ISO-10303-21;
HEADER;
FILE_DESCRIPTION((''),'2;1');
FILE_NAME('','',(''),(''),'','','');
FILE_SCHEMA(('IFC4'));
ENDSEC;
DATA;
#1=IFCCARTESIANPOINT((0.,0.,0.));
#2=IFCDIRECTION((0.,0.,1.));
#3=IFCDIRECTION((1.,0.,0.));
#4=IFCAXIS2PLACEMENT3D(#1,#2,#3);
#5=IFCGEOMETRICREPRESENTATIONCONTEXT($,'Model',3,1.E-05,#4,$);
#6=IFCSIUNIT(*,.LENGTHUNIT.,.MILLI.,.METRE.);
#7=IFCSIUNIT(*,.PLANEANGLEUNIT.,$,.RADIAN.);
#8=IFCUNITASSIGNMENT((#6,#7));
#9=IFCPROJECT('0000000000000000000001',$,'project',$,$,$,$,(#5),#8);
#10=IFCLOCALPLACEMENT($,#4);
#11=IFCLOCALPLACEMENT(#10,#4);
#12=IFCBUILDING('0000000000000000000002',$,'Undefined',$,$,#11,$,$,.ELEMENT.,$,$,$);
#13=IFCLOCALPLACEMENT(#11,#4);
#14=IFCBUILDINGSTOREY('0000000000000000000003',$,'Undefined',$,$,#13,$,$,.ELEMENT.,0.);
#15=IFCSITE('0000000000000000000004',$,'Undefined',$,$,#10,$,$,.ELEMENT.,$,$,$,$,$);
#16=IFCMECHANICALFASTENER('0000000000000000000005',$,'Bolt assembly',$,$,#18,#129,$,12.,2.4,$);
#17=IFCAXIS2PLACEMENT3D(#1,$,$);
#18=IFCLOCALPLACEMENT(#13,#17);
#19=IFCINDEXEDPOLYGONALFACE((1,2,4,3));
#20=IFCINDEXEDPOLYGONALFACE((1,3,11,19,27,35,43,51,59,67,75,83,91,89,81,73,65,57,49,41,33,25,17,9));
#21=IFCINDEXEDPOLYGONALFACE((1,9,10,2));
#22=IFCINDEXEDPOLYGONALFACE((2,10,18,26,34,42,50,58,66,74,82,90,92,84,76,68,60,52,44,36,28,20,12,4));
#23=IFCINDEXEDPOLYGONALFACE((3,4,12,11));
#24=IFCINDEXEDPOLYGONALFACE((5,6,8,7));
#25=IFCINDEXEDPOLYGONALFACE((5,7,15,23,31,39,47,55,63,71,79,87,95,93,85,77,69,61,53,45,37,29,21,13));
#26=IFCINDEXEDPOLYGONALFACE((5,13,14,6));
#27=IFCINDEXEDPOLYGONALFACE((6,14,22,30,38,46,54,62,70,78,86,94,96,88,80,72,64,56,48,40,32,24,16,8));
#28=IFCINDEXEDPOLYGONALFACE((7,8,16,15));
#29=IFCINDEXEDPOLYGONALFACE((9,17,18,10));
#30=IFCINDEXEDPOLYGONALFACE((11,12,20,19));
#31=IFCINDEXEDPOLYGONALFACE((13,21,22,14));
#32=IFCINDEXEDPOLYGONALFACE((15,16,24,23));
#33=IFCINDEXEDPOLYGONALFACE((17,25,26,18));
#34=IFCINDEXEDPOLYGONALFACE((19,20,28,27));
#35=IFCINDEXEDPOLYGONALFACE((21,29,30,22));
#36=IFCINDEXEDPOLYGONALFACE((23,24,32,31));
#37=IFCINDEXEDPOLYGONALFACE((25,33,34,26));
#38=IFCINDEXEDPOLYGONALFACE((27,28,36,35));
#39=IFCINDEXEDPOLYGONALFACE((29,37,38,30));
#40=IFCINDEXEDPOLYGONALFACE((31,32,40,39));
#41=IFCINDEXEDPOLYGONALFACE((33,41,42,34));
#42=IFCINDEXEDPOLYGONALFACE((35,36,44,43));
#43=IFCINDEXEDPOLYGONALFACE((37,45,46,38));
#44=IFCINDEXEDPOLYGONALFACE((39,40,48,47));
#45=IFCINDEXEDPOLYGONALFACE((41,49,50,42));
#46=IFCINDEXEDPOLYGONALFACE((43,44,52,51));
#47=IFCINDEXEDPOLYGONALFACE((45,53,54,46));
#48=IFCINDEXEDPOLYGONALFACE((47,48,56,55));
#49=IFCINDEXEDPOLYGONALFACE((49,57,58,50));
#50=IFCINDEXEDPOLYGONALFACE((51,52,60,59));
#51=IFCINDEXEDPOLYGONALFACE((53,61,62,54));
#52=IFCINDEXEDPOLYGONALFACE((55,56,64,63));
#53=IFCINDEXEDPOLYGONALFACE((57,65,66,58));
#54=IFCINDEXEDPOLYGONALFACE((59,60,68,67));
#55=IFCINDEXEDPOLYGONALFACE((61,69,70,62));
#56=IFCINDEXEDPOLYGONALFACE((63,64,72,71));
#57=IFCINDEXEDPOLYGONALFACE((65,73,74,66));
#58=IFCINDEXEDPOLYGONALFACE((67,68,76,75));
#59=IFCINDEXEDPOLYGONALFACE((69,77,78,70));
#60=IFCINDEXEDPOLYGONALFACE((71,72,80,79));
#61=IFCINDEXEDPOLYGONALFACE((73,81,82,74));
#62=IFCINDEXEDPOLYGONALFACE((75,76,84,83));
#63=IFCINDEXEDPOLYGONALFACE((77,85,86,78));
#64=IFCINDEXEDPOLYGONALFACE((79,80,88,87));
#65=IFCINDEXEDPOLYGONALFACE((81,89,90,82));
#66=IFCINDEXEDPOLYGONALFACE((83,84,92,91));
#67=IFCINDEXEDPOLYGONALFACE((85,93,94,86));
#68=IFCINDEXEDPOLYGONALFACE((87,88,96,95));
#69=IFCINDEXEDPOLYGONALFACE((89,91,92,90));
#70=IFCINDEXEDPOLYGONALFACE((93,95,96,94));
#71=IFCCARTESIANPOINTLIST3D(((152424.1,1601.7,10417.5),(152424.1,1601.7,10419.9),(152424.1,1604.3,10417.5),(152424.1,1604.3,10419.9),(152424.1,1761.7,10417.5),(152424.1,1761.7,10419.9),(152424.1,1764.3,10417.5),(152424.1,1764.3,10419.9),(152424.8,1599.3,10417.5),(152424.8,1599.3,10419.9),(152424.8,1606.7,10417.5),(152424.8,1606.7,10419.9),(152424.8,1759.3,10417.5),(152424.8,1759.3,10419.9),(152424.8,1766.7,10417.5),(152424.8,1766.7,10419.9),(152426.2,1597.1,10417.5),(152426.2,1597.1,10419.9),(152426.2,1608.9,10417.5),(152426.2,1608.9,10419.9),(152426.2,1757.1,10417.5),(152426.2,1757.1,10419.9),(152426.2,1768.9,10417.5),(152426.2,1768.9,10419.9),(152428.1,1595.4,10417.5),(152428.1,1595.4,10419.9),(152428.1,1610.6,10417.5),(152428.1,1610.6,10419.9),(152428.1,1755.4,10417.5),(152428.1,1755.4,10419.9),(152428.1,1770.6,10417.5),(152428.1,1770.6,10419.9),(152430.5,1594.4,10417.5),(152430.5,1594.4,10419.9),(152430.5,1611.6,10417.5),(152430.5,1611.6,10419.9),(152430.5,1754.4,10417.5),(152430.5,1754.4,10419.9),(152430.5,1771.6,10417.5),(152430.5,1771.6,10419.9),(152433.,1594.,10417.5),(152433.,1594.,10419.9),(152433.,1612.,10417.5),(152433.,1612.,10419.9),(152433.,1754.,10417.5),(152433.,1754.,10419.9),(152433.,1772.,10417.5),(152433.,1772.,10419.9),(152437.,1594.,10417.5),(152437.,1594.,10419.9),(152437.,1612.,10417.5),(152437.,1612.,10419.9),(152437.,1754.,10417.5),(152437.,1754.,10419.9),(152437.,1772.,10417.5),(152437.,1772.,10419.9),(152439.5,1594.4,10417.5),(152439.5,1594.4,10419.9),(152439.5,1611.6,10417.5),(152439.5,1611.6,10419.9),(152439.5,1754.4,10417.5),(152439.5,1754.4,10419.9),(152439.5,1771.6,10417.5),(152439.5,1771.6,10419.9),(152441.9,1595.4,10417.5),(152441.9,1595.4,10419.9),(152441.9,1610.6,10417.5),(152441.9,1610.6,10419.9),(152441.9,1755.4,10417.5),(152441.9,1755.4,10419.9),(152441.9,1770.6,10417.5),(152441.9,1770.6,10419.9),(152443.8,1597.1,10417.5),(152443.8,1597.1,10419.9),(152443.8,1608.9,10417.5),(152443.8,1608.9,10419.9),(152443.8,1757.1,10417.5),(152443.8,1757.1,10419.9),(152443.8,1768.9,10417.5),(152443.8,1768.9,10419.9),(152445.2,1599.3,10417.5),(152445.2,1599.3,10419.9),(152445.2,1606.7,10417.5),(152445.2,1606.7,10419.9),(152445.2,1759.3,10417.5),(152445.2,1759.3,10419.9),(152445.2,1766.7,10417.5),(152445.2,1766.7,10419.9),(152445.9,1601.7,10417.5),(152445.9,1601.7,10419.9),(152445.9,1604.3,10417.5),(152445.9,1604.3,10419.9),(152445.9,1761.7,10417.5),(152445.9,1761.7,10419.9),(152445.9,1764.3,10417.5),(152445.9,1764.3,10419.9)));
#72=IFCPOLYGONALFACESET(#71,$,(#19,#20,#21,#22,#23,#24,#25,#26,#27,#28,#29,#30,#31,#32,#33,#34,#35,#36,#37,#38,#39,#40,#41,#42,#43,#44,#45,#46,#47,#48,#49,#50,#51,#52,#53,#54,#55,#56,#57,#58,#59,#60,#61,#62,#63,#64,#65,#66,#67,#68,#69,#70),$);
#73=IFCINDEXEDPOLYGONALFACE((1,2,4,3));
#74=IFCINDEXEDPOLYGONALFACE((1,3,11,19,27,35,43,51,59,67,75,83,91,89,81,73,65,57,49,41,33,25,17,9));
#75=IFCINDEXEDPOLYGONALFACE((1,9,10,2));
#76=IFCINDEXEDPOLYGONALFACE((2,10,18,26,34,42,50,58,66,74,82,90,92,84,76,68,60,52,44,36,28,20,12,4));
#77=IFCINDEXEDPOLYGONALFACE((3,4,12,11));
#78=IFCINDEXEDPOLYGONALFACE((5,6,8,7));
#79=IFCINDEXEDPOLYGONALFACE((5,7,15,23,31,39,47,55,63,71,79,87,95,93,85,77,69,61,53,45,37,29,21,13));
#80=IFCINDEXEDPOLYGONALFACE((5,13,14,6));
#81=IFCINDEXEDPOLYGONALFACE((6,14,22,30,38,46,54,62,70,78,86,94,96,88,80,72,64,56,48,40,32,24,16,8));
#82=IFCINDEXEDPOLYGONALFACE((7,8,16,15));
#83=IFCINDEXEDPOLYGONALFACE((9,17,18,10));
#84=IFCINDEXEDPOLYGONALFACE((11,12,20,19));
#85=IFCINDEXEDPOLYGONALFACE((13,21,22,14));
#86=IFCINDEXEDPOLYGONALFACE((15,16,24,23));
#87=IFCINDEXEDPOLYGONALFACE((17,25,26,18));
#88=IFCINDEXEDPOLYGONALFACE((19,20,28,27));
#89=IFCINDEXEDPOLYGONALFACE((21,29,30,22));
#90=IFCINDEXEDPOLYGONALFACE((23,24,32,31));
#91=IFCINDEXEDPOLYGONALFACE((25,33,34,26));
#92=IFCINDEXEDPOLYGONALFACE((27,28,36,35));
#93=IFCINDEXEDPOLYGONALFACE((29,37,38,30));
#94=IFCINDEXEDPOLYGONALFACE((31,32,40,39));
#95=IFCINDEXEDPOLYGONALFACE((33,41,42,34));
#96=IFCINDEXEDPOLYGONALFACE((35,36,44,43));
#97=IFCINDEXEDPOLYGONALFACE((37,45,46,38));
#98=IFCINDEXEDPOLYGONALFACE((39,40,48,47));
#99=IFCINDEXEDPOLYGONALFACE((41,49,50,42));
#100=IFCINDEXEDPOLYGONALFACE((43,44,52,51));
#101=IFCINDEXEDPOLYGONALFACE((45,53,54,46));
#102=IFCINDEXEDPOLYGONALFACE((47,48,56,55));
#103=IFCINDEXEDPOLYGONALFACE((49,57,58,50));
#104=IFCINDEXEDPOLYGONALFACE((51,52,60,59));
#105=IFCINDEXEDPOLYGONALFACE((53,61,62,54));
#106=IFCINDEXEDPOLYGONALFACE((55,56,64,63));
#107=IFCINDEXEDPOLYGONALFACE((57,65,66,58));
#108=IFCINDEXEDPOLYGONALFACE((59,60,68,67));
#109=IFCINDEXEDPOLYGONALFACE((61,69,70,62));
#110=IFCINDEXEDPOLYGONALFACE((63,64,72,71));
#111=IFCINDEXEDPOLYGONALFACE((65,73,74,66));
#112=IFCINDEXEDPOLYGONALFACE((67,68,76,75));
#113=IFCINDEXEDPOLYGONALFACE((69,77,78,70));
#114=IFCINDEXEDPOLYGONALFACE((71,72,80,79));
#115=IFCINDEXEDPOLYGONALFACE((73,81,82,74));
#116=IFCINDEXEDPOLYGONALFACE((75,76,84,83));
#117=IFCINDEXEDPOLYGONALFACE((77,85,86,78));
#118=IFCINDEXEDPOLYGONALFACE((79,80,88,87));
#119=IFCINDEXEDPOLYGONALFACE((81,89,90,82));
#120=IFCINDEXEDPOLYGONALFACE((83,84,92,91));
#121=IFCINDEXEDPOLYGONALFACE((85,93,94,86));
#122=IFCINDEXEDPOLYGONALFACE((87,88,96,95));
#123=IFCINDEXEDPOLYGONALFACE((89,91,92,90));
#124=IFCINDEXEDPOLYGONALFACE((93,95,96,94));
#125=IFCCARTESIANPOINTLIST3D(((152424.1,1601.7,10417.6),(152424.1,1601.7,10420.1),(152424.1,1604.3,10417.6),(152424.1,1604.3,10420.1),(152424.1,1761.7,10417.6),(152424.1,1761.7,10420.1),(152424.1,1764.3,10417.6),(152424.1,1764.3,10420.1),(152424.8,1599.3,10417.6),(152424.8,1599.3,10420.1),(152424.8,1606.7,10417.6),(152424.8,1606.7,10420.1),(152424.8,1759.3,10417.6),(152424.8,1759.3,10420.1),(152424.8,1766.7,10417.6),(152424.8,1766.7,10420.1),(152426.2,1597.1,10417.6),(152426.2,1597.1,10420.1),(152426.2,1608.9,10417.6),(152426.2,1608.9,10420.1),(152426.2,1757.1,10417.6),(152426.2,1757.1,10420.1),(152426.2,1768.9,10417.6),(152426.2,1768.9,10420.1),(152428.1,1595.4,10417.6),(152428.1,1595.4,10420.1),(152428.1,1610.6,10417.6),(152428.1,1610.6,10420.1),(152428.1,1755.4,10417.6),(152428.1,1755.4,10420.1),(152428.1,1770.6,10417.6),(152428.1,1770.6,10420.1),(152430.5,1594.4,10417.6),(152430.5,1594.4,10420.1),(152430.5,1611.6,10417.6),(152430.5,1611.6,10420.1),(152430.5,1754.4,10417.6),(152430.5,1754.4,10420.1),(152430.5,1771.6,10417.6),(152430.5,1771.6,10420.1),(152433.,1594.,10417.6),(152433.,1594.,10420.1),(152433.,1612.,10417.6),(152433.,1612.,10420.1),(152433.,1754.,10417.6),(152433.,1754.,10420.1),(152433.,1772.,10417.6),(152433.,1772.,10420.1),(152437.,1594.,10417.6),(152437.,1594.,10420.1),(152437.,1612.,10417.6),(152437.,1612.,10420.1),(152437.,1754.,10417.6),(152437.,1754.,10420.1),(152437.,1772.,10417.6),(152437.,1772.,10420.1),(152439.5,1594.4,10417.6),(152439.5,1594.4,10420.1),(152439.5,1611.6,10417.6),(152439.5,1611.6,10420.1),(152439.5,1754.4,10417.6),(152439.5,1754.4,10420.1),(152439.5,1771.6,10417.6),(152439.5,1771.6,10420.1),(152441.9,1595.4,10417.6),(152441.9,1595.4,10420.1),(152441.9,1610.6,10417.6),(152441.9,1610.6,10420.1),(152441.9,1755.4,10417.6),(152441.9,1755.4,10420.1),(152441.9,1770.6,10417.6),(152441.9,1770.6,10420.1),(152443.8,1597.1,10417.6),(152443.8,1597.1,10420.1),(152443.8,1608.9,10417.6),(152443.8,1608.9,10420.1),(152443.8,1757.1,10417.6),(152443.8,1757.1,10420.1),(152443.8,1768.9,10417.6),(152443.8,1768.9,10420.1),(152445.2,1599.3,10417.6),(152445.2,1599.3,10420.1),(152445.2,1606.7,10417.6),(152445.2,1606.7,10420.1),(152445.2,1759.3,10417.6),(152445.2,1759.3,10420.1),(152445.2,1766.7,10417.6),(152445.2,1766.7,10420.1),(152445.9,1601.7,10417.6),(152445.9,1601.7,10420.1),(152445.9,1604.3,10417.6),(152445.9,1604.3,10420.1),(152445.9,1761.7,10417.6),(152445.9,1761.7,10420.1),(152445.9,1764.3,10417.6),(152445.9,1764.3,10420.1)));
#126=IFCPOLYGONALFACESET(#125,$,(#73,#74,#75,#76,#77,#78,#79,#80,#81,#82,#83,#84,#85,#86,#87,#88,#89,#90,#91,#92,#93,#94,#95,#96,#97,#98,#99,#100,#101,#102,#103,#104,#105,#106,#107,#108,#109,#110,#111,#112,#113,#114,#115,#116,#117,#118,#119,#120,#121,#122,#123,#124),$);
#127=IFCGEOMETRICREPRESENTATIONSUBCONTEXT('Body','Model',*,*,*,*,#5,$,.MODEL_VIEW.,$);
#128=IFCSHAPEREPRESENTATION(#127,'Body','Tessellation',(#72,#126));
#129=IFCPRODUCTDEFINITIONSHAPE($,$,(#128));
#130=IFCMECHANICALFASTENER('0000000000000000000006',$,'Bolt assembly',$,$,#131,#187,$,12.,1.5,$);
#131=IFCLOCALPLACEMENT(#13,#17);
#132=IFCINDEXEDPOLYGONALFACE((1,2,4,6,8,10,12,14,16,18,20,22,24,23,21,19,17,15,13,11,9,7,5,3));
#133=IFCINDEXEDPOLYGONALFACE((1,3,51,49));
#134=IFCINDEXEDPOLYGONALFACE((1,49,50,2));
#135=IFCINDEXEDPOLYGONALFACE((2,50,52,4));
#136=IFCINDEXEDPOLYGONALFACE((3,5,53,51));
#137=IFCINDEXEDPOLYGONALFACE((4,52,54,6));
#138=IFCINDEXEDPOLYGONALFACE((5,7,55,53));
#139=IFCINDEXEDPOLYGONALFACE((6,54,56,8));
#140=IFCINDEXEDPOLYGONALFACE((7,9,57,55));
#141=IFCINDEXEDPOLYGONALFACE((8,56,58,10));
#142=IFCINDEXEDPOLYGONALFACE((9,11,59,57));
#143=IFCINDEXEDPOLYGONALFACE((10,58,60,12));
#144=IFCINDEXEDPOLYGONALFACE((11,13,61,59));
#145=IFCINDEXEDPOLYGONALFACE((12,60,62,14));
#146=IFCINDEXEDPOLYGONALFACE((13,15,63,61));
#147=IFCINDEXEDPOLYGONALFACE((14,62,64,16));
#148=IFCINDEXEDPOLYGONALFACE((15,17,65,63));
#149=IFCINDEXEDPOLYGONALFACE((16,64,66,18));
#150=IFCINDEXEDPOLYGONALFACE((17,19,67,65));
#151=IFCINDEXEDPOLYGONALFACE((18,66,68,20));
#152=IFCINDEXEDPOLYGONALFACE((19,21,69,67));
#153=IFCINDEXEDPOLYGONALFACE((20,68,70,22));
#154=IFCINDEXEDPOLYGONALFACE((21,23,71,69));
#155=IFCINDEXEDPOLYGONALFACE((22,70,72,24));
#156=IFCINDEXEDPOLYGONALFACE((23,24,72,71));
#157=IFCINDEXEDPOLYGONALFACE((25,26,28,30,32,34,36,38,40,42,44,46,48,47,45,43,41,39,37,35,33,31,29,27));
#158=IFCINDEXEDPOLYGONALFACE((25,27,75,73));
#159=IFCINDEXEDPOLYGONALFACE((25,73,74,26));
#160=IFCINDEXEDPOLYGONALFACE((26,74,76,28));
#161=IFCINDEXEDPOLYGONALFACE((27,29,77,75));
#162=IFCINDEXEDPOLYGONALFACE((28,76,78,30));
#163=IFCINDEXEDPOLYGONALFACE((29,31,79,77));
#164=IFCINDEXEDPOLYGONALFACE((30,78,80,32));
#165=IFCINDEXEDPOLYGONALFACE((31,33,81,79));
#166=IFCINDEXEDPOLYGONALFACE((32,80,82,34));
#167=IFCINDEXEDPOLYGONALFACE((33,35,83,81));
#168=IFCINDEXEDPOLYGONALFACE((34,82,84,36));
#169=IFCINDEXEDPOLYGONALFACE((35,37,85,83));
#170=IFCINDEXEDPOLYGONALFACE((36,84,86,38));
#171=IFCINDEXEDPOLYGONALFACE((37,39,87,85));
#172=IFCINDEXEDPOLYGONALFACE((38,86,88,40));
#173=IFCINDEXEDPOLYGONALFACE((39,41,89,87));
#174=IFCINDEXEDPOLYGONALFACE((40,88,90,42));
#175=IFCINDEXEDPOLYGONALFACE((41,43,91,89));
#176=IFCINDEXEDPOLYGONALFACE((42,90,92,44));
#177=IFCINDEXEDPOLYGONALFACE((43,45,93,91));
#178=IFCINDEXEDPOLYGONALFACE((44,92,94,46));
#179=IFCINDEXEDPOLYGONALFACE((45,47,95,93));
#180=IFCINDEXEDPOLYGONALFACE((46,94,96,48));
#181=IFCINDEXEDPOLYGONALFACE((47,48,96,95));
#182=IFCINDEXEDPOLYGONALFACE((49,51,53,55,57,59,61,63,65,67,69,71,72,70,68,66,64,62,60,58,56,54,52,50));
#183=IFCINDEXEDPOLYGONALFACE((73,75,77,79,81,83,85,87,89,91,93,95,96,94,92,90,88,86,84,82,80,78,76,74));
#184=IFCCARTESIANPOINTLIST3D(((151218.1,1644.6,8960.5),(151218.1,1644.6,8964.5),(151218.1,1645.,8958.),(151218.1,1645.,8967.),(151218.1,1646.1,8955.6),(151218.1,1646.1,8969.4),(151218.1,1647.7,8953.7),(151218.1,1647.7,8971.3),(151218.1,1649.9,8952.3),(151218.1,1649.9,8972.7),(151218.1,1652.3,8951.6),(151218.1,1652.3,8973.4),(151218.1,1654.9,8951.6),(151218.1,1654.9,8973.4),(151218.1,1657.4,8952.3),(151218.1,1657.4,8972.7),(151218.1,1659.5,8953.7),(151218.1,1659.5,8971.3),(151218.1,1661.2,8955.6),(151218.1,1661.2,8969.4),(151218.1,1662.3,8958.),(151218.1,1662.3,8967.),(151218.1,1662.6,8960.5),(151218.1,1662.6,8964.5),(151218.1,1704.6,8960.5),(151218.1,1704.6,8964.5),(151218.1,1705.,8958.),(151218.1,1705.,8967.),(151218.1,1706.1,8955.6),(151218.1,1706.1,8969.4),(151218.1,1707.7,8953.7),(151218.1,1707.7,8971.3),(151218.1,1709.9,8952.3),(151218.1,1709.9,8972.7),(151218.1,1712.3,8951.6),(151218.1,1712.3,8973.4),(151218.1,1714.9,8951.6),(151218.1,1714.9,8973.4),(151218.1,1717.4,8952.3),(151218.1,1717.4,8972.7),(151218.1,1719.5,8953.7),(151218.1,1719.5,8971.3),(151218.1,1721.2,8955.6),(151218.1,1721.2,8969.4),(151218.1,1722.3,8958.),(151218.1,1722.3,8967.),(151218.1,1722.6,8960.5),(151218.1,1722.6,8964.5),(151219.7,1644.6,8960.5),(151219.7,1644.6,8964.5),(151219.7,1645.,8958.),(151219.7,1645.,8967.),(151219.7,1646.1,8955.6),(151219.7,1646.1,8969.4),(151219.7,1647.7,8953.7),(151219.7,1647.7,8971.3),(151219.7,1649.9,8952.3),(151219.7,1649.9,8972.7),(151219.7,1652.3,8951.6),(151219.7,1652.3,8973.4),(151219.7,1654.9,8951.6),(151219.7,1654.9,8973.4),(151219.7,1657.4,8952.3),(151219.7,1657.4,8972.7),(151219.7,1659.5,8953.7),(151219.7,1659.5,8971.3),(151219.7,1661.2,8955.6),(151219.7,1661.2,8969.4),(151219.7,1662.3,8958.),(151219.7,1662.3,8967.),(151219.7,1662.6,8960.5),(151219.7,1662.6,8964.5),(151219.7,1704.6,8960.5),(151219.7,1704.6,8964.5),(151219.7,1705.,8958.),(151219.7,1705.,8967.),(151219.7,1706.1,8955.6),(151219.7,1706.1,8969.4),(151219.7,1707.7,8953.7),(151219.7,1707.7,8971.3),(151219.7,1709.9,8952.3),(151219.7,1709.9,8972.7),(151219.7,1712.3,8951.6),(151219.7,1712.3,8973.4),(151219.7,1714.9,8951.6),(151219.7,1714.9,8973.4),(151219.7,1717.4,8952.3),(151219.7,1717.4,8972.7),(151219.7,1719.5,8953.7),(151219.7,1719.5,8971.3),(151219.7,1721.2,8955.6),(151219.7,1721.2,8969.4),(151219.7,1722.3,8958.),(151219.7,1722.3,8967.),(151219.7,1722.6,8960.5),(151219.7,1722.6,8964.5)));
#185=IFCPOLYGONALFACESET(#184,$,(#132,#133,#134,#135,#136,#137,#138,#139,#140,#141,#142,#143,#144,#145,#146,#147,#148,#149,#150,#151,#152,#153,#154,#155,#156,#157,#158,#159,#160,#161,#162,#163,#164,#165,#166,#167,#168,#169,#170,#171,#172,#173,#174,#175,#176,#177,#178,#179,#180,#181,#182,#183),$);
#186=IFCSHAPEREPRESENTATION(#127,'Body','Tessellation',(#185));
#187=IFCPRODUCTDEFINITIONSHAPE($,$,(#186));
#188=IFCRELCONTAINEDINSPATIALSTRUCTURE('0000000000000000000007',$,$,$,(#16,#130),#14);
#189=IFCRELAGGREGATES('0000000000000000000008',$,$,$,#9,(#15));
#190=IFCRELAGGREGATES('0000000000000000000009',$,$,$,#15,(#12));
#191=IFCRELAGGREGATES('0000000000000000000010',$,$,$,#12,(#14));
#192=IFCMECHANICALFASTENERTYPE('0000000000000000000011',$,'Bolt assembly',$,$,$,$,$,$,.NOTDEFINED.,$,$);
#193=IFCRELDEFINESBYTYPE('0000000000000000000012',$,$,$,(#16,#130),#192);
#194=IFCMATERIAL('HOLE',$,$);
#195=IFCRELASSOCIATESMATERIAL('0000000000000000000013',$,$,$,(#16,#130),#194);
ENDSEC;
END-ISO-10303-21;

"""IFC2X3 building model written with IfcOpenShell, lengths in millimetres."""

from ifc_helpers import new_model, entity, si_unit, frame, frame_2d, origin_with_axes, place, context, subcontext, project, spatial, polyline, circle_curve, parameter, trimmed, segment, composite_curve, outline, extrude, source, transform, mapped, material, type_object, element, save


model = new_model("IFC2X3")

# Units and contexts
model_context = context("Model", 3, precision=1e-05, world=origin_with_axes())
body_context = subcontext(model_context, "Body", "Model", "MODEL_VIEW")
ifc_project = project(units=[si_unit("LENGTHUNIT", "METRE", prefix="MILLI"), si_unit("PLANEANGLEUNIT", "RADIAN")], contexts=[model_context])

# Site, building, storey
site_placement = place(None, origin_with_axes())
site = spatial("IfcSite", under=ifc_project, at=site_placement, Name="Undefined", CompositionType="ELEMENT")
building_placement = place(site_placement, origin_with_axes())
building = spatial("IfcBuilding", under=site, at=building_placement, Name="Undefined", CompositionType="ELEMENT")
storey_placement = place(building_placement, origin_with_axes())
storey = spatial("IfcBuildingStorey", under=building, at=storey_placement, Name="Undefined", CompositionType="ELEMENT", Elevation=0.0)

# Mechanical fasteners
ifc_material_1 = material(Name="HOLE")
mechanical_fastener_type = type_object("IfcMechanicalFastenerType", Name="Bolt assembly")
shared_circle_1 = entity("IfcCircle", entity("IfcAxis2Placement2D", entity("IfcCartesianPoint", [2.0, 0.0]), entity("IfcDirection", [0.0, 1.0])), 9.0)
shared_circle_2 = entity("IfcCircle", entity("IfcAxis2Placement2D", entity("IfcCartesianPoint", [-2.0, 0.0]), entity("IfcDirection", [0.0, -1.0])), 9.0)
shared_composite_curve = entity("IfcCompositeCurve", [entity("IfcCompositeCurveSegment", "CONTINUOUS", True, entity("IfcPolyline", [entity("IfcCartesianPoint", [-2.0, 9.0]), entity("IfcCartesianPoint", [2.0, 9.0])])), entity("IfcCompositeCurveSegment", "CONTINUOUS", True, entity("IfcTrimmedCurve", shared_circle_1, [entity("IfcParameterValue", 0.0)], [entity("IfcParameterValue", 3.141593)], False, "PARAMETER")), entity("IfcCompositeCurveSegment", "CONTINUOUS", True, entity("IfcPolyline", [entity("IfcCartesianPoint", [2.0, -9.0]), entity("IfcCartesianPoint", [-2.0, -9.0])])), entity("IfcCompositeCurveSegment", "DISCONTINUOUS", True, entity("IfcTrimmedCurve", shared_circle_2, [entity("IfcParameterValue", 0.0)], [entity("IfcParameterValue", 3.141593)], False, "PARAMETER"))], False)
shared_shape_1 = source(origin_with_axes(), body_context, "Body", "SweptSolid", [
    entity("IfcExtrudedAreaSolid", entity("IfcArbitraryClosedProfileDef", "AREA", None, shared_composite_curve), entity("IfcAxis2Placement3D", entity("IfcCartesianPoint", [0.0, -2.3, 0.0]), entity("IfcDirection", [0.0, 1.0, 0.0]), entity("IfcDirection", [1.0, 0.0, 0.0])), entity("IfcDirection", [0.0, 0.0, 1.0]), 2.4),
    entity("IfcExtrudedAreaSolid", entity("IfcArbitraryClosedProfileDef", "AREA", None, shared_composite_curve), entity("IfcAxis2Placement3D", entity("IfcCartesianPoint", [0.0, -2.5, 0.0]), entity("IfcDirection", [0.0, 1.0, 0.0]), entity("IfcDirection", [1.0, 0.0, 0.0])), entity("IfcDirection", [0.0, 0.0, 1.0]), 2.5),
])
mechanical_fastener_1_placement = place(storey_placement, frame((152435.0, 1683.0, 10417.6), z_axis=(0.0, 1.0, 0.0), x_axis=(1.0, 0.0, 0.0)))
element("IfcMechanicalFastener", 1, at=mechanical_fastener_1_placement, inside=storey, type_object=mechanical_fastener_type, material=ifc_material_1, Name="Bolt assembly", NominalDiameter=12.0, NominalLength=2.4, context=body_context, shape_type="MappedRepresentation", body=[
    mapped(shared_shape_1, transform((0.0, 0.0, -80.0))),
    mapped(shared_shape_1, transform((0.0, 0.0, 80.0))),
])
shared_shape_2 = source(origin_with_axes(), body_context, "Body", "SweptSolid", [
    extrude(outline(composite_curve([segment(polyline([(9.0, 2.0), (9.0, -2.0)]), True, "CONTINUOUS"), segment(trimmed(circle_curve(frame_2d((0.0, -2.0), x_axis=(1.0, 0.0)), 9.0), [parameter(0.0)], [parameter(3.141593)], False, "PARAMETER"), True, "CONTINUOUS"), segment(polyline([(-9.0, -2.0), (-9.0, 2.0)]), True, "CONTINUOUS"), segment(trimmed(circle_curve(frame_2d((0.0, 2.0), x_axis=(-1.0, 0.0)), 9.0), [parameter(0.0)], [parameter(3.141593)], False, "PARAMETER"), True, "DISCONTINUOUS")], self_intersect=False)), frame((0.0, 0.0, 0.0), z_axis=(0.0, 1.0, 0.0), x_axis=(1.0, 0.0, 0.0)), (0.0, 0.0, 1.0), 1.6),
])
mechanical_fastener_2_placement = place(storey_placement, frame((151218.1, 1653.6, 8962.5), z_axis=(0.0, 0.0, -1.0), x_axis=(0.0, 1.0, 0.0)))
element("IfcMechanicalFastener", 2, at=mechanical_fastener_2_placement, inside=storey, type_object=mechanical_fastener_type, material=ifc_material_1, Name="Bolt assembly", NominalDiameter=12.0, NominalLength=1.5, context=body_context, shape_type="MappedRepresentation", body=[
    mapped(shared_shape_2, transform((0.0, 0.0, 0.0))),
    mapped(shared_shape_2, transform((60.0, 0.0, 0.0))),
])

save(model, "model.ifc")
